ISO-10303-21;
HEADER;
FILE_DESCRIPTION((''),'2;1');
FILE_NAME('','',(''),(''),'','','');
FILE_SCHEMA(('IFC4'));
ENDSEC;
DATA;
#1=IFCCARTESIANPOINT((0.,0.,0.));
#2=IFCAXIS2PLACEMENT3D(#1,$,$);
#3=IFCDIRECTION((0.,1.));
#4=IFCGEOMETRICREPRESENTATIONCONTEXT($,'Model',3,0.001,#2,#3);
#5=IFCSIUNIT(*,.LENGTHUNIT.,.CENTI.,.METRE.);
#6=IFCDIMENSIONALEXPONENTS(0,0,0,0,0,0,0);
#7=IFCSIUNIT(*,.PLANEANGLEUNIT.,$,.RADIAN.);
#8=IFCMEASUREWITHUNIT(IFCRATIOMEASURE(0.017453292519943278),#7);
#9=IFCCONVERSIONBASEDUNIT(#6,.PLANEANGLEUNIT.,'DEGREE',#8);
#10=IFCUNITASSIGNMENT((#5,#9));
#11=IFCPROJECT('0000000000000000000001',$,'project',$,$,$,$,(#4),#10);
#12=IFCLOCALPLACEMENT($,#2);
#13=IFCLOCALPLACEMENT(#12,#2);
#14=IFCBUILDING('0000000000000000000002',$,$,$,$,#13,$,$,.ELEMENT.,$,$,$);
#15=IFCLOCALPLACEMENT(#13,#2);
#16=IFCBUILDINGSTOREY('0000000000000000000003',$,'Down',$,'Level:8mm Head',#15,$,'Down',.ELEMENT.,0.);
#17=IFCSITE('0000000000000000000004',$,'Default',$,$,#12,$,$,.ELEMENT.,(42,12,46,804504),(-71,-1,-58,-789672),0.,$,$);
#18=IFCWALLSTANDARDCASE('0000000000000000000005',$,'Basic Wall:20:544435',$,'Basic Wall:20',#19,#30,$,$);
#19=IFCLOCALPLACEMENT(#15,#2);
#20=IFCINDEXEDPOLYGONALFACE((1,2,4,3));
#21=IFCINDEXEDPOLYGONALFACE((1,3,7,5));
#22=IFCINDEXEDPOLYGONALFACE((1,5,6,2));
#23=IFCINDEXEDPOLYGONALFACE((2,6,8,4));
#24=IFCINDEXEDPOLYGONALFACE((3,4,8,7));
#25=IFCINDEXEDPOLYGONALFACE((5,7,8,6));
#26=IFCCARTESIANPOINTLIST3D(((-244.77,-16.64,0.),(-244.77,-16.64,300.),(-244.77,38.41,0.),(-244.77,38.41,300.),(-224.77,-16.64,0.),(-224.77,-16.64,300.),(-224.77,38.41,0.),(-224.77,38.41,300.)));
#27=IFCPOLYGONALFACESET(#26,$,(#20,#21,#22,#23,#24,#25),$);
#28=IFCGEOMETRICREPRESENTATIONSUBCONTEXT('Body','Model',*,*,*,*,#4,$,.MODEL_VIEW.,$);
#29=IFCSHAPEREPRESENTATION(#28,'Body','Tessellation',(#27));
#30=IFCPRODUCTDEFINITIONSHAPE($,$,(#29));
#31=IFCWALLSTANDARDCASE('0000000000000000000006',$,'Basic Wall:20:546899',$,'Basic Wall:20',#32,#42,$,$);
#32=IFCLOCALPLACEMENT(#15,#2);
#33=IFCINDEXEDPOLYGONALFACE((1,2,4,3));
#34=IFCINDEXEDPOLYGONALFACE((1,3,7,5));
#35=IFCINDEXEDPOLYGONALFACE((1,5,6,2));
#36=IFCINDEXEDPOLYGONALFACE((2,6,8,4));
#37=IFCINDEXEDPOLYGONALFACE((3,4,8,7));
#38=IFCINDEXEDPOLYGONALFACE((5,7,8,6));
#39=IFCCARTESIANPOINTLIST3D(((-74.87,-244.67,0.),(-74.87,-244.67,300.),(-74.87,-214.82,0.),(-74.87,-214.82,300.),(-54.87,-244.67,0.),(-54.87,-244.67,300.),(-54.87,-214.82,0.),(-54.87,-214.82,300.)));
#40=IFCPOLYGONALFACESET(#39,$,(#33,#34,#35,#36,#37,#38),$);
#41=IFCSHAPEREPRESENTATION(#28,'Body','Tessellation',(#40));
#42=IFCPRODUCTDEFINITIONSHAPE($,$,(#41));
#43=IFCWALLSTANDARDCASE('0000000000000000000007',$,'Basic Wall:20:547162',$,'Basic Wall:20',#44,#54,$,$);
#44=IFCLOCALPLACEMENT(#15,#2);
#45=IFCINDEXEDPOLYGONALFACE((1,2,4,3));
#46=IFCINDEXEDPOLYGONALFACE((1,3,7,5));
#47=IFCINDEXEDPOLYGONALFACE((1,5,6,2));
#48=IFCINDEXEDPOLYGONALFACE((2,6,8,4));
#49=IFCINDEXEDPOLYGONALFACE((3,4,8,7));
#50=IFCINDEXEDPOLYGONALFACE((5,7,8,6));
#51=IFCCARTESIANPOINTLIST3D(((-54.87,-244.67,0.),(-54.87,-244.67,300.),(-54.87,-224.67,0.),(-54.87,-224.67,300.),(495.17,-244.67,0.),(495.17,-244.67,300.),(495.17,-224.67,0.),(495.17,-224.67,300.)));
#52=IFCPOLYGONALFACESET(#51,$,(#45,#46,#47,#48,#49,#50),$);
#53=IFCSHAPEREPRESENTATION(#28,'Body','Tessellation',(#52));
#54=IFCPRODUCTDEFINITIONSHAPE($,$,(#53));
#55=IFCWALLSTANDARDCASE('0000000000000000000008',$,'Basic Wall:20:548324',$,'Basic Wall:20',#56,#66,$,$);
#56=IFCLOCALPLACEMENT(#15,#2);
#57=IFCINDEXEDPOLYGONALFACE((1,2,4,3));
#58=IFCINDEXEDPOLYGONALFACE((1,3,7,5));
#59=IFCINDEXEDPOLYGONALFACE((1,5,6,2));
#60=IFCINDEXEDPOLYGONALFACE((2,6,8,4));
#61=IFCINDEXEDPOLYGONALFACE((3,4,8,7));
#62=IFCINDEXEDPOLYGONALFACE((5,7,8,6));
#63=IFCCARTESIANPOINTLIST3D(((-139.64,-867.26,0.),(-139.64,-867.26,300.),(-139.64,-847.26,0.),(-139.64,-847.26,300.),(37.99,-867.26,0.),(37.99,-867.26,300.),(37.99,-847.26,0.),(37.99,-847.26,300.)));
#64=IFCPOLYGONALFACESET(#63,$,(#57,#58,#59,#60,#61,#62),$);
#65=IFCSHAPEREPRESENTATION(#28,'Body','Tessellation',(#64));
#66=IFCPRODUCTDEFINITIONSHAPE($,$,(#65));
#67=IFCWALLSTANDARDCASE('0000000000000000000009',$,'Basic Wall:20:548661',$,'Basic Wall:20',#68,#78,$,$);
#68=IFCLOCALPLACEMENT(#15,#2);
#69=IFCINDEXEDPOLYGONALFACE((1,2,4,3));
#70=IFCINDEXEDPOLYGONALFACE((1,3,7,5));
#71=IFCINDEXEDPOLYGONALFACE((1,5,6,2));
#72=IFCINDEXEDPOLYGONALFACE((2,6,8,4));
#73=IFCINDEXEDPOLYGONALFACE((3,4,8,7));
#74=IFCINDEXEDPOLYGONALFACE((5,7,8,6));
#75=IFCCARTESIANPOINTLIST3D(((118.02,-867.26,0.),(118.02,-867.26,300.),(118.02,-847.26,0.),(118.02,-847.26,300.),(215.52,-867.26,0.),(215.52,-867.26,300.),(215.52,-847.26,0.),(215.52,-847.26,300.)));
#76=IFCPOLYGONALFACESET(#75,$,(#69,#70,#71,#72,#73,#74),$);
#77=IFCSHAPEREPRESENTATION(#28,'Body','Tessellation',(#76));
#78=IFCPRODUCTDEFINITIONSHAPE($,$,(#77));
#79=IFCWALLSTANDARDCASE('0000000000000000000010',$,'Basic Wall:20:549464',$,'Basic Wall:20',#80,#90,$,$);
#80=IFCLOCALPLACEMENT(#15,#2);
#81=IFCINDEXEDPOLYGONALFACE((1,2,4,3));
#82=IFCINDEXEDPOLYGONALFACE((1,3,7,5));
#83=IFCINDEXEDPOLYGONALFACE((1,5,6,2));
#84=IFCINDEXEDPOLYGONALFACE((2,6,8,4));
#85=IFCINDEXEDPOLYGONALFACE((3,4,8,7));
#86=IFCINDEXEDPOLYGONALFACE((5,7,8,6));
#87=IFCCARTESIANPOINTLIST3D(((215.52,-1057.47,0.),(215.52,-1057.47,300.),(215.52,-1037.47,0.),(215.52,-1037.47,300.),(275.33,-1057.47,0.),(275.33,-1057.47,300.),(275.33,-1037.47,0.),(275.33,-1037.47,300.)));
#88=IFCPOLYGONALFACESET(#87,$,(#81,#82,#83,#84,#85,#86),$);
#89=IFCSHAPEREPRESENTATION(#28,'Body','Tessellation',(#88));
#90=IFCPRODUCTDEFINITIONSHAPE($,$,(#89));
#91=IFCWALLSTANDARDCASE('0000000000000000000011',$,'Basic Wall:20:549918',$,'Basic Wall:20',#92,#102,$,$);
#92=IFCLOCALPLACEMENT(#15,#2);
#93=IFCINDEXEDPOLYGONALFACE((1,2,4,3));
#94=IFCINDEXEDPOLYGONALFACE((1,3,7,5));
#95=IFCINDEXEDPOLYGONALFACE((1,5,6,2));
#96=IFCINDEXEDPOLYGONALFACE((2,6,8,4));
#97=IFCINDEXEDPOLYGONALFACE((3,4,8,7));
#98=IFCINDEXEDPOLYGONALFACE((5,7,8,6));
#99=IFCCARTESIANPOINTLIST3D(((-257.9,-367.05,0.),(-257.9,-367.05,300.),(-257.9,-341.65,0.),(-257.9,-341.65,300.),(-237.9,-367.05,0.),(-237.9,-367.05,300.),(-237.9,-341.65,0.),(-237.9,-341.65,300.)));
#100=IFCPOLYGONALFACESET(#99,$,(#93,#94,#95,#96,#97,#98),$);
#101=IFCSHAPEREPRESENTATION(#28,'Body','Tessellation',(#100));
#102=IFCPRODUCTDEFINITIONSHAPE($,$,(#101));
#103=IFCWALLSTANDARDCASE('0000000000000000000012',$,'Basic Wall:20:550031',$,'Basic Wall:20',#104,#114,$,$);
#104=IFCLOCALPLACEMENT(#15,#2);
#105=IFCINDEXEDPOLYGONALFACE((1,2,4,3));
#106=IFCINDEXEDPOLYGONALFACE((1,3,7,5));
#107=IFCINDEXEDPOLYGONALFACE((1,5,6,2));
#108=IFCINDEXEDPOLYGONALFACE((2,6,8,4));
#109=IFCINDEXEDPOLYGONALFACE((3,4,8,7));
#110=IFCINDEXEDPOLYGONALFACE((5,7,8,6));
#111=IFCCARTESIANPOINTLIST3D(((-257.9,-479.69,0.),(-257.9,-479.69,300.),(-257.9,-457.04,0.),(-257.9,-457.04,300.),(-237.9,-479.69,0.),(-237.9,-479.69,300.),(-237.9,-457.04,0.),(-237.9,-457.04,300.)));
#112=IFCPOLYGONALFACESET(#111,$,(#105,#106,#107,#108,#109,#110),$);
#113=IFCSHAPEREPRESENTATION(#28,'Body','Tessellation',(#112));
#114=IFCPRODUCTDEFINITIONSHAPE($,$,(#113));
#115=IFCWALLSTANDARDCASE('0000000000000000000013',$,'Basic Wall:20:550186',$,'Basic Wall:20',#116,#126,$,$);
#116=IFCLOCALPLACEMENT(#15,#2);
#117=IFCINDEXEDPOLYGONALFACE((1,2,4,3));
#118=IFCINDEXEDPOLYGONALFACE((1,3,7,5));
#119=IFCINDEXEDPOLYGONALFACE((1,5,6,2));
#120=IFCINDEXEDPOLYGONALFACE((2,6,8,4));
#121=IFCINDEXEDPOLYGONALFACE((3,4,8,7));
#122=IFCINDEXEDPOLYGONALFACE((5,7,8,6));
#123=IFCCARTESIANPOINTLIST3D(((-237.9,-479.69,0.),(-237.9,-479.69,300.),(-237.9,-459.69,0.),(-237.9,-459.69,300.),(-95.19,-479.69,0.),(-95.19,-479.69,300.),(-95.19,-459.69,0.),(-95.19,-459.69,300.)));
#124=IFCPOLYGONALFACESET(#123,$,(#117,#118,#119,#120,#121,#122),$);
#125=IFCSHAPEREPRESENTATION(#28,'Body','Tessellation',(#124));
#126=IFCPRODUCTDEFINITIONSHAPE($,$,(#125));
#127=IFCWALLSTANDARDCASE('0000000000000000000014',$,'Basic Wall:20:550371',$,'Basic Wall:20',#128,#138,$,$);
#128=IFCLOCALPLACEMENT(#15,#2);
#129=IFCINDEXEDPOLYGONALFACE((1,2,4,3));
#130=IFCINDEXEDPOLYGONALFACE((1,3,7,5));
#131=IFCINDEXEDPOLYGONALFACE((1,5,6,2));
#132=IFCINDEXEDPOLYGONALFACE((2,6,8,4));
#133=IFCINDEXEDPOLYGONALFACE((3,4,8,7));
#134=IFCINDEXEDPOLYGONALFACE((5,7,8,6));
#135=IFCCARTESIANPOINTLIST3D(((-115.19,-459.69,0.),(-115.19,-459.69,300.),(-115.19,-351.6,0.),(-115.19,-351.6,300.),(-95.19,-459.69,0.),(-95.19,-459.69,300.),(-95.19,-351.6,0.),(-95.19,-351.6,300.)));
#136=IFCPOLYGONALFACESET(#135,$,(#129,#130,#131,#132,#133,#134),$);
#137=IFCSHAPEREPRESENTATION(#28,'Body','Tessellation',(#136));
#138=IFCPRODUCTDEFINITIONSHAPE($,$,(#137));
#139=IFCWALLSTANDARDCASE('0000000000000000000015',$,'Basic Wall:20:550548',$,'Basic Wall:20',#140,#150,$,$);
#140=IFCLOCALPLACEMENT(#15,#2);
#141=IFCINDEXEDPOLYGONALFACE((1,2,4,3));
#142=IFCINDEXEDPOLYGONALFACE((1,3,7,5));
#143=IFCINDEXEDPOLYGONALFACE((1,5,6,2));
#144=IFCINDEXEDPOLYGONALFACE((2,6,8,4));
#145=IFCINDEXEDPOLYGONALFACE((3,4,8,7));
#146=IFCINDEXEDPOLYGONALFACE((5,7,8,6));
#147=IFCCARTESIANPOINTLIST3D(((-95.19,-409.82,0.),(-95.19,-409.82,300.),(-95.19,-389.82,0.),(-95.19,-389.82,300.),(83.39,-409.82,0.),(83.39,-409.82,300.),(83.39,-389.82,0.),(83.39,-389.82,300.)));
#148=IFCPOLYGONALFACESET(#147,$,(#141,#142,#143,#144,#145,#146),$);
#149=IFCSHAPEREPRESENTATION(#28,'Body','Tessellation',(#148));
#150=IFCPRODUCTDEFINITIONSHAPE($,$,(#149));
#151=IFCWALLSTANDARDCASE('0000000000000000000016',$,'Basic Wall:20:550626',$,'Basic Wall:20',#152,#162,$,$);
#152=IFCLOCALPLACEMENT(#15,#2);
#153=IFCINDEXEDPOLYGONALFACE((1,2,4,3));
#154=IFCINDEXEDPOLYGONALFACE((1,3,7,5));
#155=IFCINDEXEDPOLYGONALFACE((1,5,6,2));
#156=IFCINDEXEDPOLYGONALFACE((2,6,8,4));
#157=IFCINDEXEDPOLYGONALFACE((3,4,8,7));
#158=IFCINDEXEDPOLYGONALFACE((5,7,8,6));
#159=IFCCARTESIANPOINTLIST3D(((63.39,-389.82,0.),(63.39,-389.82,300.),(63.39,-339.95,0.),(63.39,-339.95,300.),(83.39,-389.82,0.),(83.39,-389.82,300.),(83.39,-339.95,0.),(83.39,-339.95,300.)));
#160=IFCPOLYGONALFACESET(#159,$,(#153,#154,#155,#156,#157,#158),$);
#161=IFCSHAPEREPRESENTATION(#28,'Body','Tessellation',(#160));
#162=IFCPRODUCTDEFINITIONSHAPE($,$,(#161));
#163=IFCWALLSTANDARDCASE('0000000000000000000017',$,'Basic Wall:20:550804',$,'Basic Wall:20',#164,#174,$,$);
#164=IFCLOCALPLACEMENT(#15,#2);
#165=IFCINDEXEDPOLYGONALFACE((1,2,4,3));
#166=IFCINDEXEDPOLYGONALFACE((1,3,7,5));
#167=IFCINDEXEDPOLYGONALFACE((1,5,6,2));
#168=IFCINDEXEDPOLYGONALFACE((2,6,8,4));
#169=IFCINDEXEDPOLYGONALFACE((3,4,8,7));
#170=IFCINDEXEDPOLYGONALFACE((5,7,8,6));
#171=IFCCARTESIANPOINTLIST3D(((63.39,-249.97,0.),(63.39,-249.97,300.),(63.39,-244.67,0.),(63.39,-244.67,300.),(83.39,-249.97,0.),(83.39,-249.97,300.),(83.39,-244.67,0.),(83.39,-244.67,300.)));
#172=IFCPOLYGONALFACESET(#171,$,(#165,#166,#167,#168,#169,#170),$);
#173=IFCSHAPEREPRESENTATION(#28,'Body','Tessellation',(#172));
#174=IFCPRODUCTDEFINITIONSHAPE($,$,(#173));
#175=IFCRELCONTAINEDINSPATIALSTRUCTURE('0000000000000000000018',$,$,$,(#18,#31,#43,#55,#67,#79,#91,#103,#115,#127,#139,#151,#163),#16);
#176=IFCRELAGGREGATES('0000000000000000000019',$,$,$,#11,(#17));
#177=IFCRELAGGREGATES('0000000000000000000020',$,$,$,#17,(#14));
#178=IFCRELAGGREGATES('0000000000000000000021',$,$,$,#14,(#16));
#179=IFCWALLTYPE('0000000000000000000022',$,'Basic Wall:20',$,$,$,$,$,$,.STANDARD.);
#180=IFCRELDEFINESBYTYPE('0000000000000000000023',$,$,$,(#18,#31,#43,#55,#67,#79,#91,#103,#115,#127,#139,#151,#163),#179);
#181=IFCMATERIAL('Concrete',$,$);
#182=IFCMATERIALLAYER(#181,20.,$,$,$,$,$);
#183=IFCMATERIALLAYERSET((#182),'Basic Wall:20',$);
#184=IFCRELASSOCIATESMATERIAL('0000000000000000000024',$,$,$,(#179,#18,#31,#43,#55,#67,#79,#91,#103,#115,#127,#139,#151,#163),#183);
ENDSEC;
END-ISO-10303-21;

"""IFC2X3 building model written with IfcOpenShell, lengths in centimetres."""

from ifc_helpers import new_model, entity, si_unit, converted_unit, direction, frame, frame_2d, origin, place, context, subcontext, project, spatial, rectangle, extrude, material, layer, layer_set, layer_usage, type_object, element, save


model = new_model("IFC2X3")

# Units and contexts
model_context = context("Model", 3, precision=0.001, world=origin(), true_north=direction((0.0, 1.0)))
body_context = subcontext(model_context, "Body", "Model", "MODEL_VIEW")
ifc_project = project(units=[si_unit("LENGTHUNIT", "METRE", prefix="CENTI"), converted_unit("PLANEANGLEUNIT", "DEGREE", entity("IfcRatioMeasure", 0.017453292519943278), si_unit("PLANEANGLEUNIT", "RADIAN"), dimensions=[0, 0, 0, 0, 0, 0, 0])], contexts=[model_context])

# Site, building, storey
site_placement = place(None, origin())
site = spatial("IfcSite", under=ifc_project, at=site_placement, Name="Default", CompositionType="ELEMENT", RefLatitude=(42, 12, 46, 804504), RefLongitude=(-71, -1, -58, -789672), RefElevation=0.0)
building_placement = place(site_placement, origin())
building = spatial("IfcBuilding", under=site, at=building_placement, CompositionType="ELEMENT")
storey_placement = place(building_placement, origin())
storey = spatial("IfcBuildingStorey", under=building, at=storey_placement, Name="Down", ObjectType="Level:8mm Head", LongName="Down", CompositionType="ELEMENT", Elevation=0.0)

# Shared definitions
ifc_material = material(Name="Concrete")

# Walls
ifc_layer_1 = layer(ifc_material, 20.0)
ifc_layer_set_1 = layer_set([ifc_layer_1], Name="Basic Wall:20")
wall_type_1 = type_object("IfcWallType", Name="Basic Wall:20", PredefinedType="STANDARD", material=ifc_layer_set_1)
ifc_layer_usage_1 = layer_usage(ifc_layer_set_1, "AXIS2", "POSITIVE", -10.0)
wall_1_placement = place(storey_placement, frame((-234.77, -16.64, 0.0), z_axis=(0.0, 0.0, 1.0), x_axis=(0.0, 1.0, 0.0)))
element("IfcWallStandardCase", 1, at=wall_1_placement, inside=storey, type_object=wall_type_1, material=ifc_layer_usage_1, Name="Basic Wall:20:544435", ObjectType="Basic Wall:20", context=body_context, shape_type="SweptSolid", body=[
    extrude(rectangle(XDim=55.05, YDim=20.0, at=frame_2d((27.52, 0.0), x_axis=(-1.0, 0.0))), origin(), (0.0, 0.0, 1.0), 300.0),
])
ifc_layer_usage_2 = layer_usage(ifc_layer_set_1, "AXIS2", "POSITIVE", -10.0)
wall_2_placement = place(storey_placement, frame((-64.87, -214.82, 0.0), z_axis=(0.0, 0.0, 1.0), x_axis=(0.0, -1.0, 0.0)))
element("IfcWallStandardCase", 2, at=wall_2_placement, inside=storey, type_object=wall_type_1, material=ifc_layer_usage_2, Name="Basic Wall:20:546899", ObjectType="Basic Wall:20", context=body_context, shape_type="SweptSolid", body=[
    extrude(rectangle(XDim=29.85, YDim=20.0, at=frame_2d((14.93, 0.0), x_axis=(-1.0, 0.0))), origin(), (0.0, 0.0, 1.0), 300.0),
])
ifc_layer_usage_3 = layer_usage(ifc_layer_set_1, "AXIS2", "POSITIVE", -10.0)
wall_3_placement = place(storey_placement, frame((-54.87, -234.67, 0.0)))
element("IfcWallStandardCase", 3, at=wall_3_placement, inside=storey, type_object=wall_type_1, material=ifc_layer_usage_3, Name="Basic Wall:20:547162", ObjectType="Basic Wall:20", context=body_context, shape_type="SweptSolid", body=[
    extrude(rectangle(XDim=550.04, YDim=20.0, at=frame_2d((275.02, 0.0), x_axis=(-1.0, 0.0))), origin(), (0.0, 0.0, 1.0), 300.0),
])
ifc_layer_usage_4 = layer_usage(ifc_layer_set_1, "AXIS2", "NEGATIVE", 10.0)
wall_4_placement = place(storey_placement, frame((-139.64, -857.26, 0.0)))
element("IfcWallStandardCase", 4, at=wall_4_placement, inside=storey, type_object=wall_type_1, material=ifc_layer_usage_4, Name="Basic Wall:20:548324", ObjectType="Basic Wall:20", context=body_context, shape_type="SweptSolid", body=[
    extrude(rectangle(XDim=177.63, YDim=20.0, at=frame_2d((88.81, 0.0), x_axis=(-1.0, 0.0))), origin(), (0.0, 0.0, 1.0), 300.0),
])
ifc_layer_usage_5 = layer_usage(ifc_layer_set_1, "AXIS2", "NEGATIVE", 10.0)
wall_5_placement = place(storey_placement, frame((118.02, -857.26, 0.0)))
element("IfcWallStandardCase", 5, at=wall_5_placement, inside=storey, type_object=wall_type_1, material=ifc_layer_usage_5, Name="Basic Wall:20:548661", ObjectType="Basic Wall:20", context=body_context, shape_type="SweptSolid", body=[
    extrude(rectangle(XDim=97.5, YDim=20.0, at=frame_2d((48.75, 0.0), x_axis=(-1.0, 0.0))), origin(), (0.0, 0.0, 1.0), 300.0),
])
ifc_layer_usage_6 = layer_usage(ifc_layer_set_1, "AXIS2", "POSITIVE", -10.0)
wall_6_placement = place(storey_placement, frame((275.33, -1047.47, 0.0), z_axis=(0.0, 0.0, 1.0), x_axis=(-1.0, 0.0, 0.0)))
element("IfcWallStandardCase", 6, at=wall_6_placement, inside=storey, type_object=wall_type_1, material=ifc_layer_usage_6, Name="Basic Wall:20:549464", ObjectType="Basic Wall:20", context=body_context, shape_type="SweptSolid", body=[
    extrude(rectangle(XDim=59.82, YDim=20.0, at=frame_2d((29.91, 0.0), x_axis=(-1.0, 0.0))), origin(), (0.0, 0.0, 1.0), 300.0),
])
ifc_layer_usage_7 = layer_usage(ifc_layer_set_1, "AXIS2", "NEGATIVE", 10.0)
wall_7_placement = place(storey_placement, frame((-247.9, -341.65, 0.0), z_axis=(0.0, 0.0, 1.0), x_axis=(0.0, -1.0, 0.0)))
element("IfcWallStandardCase", 7, at=wall_7_placement, inside=storey, type_object=wall_type_1, material=ifc_layer_usage_7, Name="Basic Wall:20:549918", ObjectType="Basic Wall:20", context=body_context, shape_type="SweptSolid", body=[
    extrude(rectangle(XDim=25.41, YDim=20.0, at=frame_2d((12.7, 0.0), x_axis=(-1.0, 0.0))), origin(), (0.0, 0.0, 1.0), 300.0),
])
ifc_layer_usage_8 = layer_usage(ifc_layer_set_1, "AXIS2", "NEGATIVE", 10.0)
wall_8_placement = place(storey_placement, frame((-247.9, -457.04, 0.0), z_axis=(0.0, 0.0, 1.0), x_axis=(0.0, -1.0, 0.0)))
element("IfcWallStandardCase", 8, at=wall_8_placement, inside=storey, type_object=wall_type_1, material=ifc_layer_usage_8, Name="Basic Wall:20:550031", ObjectType="Basic Wall:20", context=body_context, shape_type="SweptSolid", body=[
    extrude(rectangle(XDim=22.66, YDim=20.0, at=frame_2d((11.33, 0.0), x_axis=(-1.0, 0.0))), origin(), (0.0, 0.0, 1.0), 300.0),
])
ifc_layer_usage_9 = layer_usage(ifc_layer_set_1, "AXIS2", "POSITIVE", -10.0)
wall_9_placement = place(storey_placement, frame((-237.9, -469.69, 0.0)))
element("IfcWallStandardCase", 9, at=wall_9_placement, inside=storey, type_object=wall_type_1, material=ifc_layer_usage_9, Name="Basic Wall:20:550186", ObjectType="Basic Wall:20", context=body_context, shape_type="SweptSolid", body=[
    extrude(rectangle(XDim=142.71, YDim=20.0, at=frame_2d((71.35, 0.0), x_axis=(-1.0, 0.0))), origin(), (0.0, 0.0, 1.0), 300.0),
])
ifc_layer_usage_10 = layer_usage(ifc_layer_set_1, "AXIS2", "POSITIVE", -10.0)
wall_10_placement = place(storey_placement, frame((-105.19, -459.69, 0.0), z_axis=(0.0, 0.0, 1.0), x_axis=(0.0, 1.0, 0.0)))
element("IfcWallStandardCase", 10, at=wall_10_placement, inside=storey, type_object=wall_type_1, material=ifc_layer_usage_10, Name="Basic Wall:20:550371", ObjectType="Basic Wall:20", context=body_context, shape_type="SweptSolid", body=[
    extrude(rectangle(XDim=108.1, YDim=20.0, at=frame_2d((54.05, 0.0), x_axis=(-1.0, 0.0))), origin(), (0.0, 0.0, 1.0), 300.0),
])
ifc_layer_usage_11 = layer_usage(ifc_layer_set_1, "AXIS2", "POSITIVE", -10.0)
wall_11_placement = place(storey_placement, frame((-95.19, -399.82, 0.0)))
element("IfcWallStandardCase", 11, at=wall_11_placement, inside=storey, type_object=wall_type_1, material=ifc_layer_usage_11, Name="Basic Wall:20:550548", ObjectType="Basic Wall:20", context=body_context, shape_type="SweptSolid", body=[
    extrude(rectangle(XDim=178.59, YDim=20.0, at=frame_2d((89.29, 0.0), x_axis=(-1.0, 0.0))), origin(), (0.0, 0.0, 1.0), 300.0),
])
ifc_layer_usage_12 = layer_usage(ifc_layer_set_1, "AXIS2", "POSITIVE", -10.0)
wall_12_placement = place(storey_placement, frame((73.39, -389.82, 0.0), z_axis=(0.0, 0.0, 1.0), x_axis=(0.0, 1.0, 0.0)))
element("IfcWallStandardCase", 12, at=wall_12_placement, inside=storey, type_object=wall_type_1, material=ifc_layer_usage_12, Name="Basic Wall:20:550626", ObjectType="Basic Wall:20", context=body_context, shape_type="SweptSolid", body=[
    extrude(rectangle(XDim=49.87, YDim=20.0, at=frame_2d((24.94, 0.0), x_axis=(-1.0, 0.0))), origin(), (0.0, 0.0, 1.0), 300.0),
])
ifc_layer_usage_13 = layer_usage(ifc_layer_set_1, "AXIS2", "NEGATIVE", 10.0)
wall_13_placement = place(storey_placement, frame((73.39, -249.97, 0.0), z_axis=(0.0, 0.0, 1.0), x_axis=(0.0, 1.0, 0.0)))
element("IfcWallStandardCase", 13, at=wall_13_placement, inside=storey, type_object=wall_type_1, material=ifc_layer_usage_13, Name="Basic Wall:20:550804", ObjectType="Basic Wall:20", context=body_context, shape_type="SweptSolid", body=[
    extrude(rectangle(XDim=5.29, YDim=20.0, at=frame_2d((2.65, 0.0), x_axis=(-1.0, 0.0))), origin(), (0.0, 0.0, 1.0), 300.0),
])

save(model, "model.ifc")
